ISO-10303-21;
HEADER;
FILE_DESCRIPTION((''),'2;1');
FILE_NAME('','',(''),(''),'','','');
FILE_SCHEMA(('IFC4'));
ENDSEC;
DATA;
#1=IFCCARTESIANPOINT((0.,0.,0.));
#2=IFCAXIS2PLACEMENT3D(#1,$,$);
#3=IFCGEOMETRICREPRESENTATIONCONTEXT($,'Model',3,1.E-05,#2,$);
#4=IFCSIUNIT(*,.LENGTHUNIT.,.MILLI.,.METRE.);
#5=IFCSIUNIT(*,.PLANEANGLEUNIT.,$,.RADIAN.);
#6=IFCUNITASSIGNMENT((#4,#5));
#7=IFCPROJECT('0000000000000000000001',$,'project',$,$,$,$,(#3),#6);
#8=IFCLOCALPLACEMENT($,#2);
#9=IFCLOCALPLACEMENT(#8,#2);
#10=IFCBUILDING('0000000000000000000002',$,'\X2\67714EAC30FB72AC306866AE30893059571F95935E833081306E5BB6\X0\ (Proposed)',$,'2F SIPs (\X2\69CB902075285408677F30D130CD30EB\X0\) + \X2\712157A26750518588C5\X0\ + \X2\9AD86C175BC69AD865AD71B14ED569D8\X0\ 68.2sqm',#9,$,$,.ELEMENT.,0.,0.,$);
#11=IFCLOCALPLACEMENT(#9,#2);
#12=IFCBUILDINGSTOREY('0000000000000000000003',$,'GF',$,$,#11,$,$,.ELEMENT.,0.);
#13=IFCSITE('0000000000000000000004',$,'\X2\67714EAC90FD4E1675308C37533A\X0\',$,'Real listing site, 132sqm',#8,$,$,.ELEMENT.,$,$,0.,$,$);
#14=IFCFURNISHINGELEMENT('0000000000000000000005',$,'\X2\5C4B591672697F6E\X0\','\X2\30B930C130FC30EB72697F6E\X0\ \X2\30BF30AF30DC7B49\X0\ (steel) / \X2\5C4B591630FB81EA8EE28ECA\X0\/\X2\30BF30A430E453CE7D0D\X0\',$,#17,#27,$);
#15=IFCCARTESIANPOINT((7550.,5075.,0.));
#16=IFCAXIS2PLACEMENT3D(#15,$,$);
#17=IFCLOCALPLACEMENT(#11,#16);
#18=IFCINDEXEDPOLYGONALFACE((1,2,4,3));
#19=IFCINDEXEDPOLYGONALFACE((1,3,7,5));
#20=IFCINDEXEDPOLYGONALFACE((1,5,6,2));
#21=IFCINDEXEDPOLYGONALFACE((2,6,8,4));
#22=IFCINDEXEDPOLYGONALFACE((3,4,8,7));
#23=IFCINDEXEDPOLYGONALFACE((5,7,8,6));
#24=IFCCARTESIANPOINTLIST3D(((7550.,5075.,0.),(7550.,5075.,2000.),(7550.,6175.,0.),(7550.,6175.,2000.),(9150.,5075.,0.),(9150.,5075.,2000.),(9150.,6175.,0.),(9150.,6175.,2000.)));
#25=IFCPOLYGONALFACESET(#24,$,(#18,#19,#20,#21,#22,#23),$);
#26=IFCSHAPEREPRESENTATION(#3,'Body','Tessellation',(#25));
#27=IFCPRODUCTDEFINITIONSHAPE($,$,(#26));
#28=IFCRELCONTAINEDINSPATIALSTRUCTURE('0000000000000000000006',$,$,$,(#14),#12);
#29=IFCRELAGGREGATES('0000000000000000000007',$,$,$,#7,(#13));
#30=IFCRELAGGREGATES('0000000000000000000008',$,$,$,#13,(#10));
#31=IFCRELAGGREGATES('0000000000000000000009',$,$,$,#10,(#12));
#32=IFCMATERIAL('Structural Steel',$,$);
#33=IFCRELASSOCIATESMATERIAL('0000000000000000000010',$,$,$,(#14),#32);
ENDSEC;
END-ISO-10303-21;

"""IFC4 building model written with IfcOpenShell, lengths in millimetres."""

from ifc_helpers import new_model, si_unit, frame, frame_2d, origin, place, context, project, spatial, rectangle, extrude, material, element, save


model = new_model("IFC4")

# Units and contexts
model_context = context("Model", 3, precision=1e-05, world=origin())
ifc_project = project(units=[si_unit("LENGTHUNIT", "METRE", prefix="MILLI"), si_unit("PLANEANGLEUNIT", "RADIAN")], contexts=[model_context])

# Site, building, storey
site_placement = place(None, origin())
site = spatial("IfcSite", under=ifc_project, at=site_placement, Name="東京都世田谷区", ObjectType="Real listing site, 132sqm", CompositionType="ELEMENT", RefElevation=0.0)
building_placement = place(site_placement, origin())
building = spatial("IfcBuilding", under=site, at=building_placement, Name="東京・犬と暮らす土間広めの家 (Proposed)", ObjectType="2F SIPs (構造用合板パネル) + 無垢材内装 + 高気密高断熱仕様 68.2sqm", CompositionType="ELEMENT", ElevationOfRefHeight=0.0, ElevationOfTerrain=0.0)
storey_placement = place(building_placement, origin())
storey = spatial("IfcBuildingStorey", under=building, at=storey_placement, Name="GF", CompositionType="ELEMENT", Elevation=0.0)

# Shared definitions
ifc_material_1 = material(Name="Structural Steel")

# Furnishing element
furnishing_1_placement = place(storey_placement, frame((7550.0, 5075.0, 0.0)))
element("IfcFurnishingElement", 1, at=furnishing_1_placement, inside=storey, material=ifc_material_1, Name="屋外物置", Description="スチール物置 タクボ等 (steel) / 屋外・自転車/タイヤ収納", context=model_context, shape_type="SweptSolid", body=[
    extrude(rectangle(XDim=1600.0, YDim=1100.0, at=frame_2d((800.0, 550.0))), frame((7550.0, 5075.0, 0.0)), (0.0, 0.0, 1.0), 2000.0),
])

save(model, "model.ifc")
